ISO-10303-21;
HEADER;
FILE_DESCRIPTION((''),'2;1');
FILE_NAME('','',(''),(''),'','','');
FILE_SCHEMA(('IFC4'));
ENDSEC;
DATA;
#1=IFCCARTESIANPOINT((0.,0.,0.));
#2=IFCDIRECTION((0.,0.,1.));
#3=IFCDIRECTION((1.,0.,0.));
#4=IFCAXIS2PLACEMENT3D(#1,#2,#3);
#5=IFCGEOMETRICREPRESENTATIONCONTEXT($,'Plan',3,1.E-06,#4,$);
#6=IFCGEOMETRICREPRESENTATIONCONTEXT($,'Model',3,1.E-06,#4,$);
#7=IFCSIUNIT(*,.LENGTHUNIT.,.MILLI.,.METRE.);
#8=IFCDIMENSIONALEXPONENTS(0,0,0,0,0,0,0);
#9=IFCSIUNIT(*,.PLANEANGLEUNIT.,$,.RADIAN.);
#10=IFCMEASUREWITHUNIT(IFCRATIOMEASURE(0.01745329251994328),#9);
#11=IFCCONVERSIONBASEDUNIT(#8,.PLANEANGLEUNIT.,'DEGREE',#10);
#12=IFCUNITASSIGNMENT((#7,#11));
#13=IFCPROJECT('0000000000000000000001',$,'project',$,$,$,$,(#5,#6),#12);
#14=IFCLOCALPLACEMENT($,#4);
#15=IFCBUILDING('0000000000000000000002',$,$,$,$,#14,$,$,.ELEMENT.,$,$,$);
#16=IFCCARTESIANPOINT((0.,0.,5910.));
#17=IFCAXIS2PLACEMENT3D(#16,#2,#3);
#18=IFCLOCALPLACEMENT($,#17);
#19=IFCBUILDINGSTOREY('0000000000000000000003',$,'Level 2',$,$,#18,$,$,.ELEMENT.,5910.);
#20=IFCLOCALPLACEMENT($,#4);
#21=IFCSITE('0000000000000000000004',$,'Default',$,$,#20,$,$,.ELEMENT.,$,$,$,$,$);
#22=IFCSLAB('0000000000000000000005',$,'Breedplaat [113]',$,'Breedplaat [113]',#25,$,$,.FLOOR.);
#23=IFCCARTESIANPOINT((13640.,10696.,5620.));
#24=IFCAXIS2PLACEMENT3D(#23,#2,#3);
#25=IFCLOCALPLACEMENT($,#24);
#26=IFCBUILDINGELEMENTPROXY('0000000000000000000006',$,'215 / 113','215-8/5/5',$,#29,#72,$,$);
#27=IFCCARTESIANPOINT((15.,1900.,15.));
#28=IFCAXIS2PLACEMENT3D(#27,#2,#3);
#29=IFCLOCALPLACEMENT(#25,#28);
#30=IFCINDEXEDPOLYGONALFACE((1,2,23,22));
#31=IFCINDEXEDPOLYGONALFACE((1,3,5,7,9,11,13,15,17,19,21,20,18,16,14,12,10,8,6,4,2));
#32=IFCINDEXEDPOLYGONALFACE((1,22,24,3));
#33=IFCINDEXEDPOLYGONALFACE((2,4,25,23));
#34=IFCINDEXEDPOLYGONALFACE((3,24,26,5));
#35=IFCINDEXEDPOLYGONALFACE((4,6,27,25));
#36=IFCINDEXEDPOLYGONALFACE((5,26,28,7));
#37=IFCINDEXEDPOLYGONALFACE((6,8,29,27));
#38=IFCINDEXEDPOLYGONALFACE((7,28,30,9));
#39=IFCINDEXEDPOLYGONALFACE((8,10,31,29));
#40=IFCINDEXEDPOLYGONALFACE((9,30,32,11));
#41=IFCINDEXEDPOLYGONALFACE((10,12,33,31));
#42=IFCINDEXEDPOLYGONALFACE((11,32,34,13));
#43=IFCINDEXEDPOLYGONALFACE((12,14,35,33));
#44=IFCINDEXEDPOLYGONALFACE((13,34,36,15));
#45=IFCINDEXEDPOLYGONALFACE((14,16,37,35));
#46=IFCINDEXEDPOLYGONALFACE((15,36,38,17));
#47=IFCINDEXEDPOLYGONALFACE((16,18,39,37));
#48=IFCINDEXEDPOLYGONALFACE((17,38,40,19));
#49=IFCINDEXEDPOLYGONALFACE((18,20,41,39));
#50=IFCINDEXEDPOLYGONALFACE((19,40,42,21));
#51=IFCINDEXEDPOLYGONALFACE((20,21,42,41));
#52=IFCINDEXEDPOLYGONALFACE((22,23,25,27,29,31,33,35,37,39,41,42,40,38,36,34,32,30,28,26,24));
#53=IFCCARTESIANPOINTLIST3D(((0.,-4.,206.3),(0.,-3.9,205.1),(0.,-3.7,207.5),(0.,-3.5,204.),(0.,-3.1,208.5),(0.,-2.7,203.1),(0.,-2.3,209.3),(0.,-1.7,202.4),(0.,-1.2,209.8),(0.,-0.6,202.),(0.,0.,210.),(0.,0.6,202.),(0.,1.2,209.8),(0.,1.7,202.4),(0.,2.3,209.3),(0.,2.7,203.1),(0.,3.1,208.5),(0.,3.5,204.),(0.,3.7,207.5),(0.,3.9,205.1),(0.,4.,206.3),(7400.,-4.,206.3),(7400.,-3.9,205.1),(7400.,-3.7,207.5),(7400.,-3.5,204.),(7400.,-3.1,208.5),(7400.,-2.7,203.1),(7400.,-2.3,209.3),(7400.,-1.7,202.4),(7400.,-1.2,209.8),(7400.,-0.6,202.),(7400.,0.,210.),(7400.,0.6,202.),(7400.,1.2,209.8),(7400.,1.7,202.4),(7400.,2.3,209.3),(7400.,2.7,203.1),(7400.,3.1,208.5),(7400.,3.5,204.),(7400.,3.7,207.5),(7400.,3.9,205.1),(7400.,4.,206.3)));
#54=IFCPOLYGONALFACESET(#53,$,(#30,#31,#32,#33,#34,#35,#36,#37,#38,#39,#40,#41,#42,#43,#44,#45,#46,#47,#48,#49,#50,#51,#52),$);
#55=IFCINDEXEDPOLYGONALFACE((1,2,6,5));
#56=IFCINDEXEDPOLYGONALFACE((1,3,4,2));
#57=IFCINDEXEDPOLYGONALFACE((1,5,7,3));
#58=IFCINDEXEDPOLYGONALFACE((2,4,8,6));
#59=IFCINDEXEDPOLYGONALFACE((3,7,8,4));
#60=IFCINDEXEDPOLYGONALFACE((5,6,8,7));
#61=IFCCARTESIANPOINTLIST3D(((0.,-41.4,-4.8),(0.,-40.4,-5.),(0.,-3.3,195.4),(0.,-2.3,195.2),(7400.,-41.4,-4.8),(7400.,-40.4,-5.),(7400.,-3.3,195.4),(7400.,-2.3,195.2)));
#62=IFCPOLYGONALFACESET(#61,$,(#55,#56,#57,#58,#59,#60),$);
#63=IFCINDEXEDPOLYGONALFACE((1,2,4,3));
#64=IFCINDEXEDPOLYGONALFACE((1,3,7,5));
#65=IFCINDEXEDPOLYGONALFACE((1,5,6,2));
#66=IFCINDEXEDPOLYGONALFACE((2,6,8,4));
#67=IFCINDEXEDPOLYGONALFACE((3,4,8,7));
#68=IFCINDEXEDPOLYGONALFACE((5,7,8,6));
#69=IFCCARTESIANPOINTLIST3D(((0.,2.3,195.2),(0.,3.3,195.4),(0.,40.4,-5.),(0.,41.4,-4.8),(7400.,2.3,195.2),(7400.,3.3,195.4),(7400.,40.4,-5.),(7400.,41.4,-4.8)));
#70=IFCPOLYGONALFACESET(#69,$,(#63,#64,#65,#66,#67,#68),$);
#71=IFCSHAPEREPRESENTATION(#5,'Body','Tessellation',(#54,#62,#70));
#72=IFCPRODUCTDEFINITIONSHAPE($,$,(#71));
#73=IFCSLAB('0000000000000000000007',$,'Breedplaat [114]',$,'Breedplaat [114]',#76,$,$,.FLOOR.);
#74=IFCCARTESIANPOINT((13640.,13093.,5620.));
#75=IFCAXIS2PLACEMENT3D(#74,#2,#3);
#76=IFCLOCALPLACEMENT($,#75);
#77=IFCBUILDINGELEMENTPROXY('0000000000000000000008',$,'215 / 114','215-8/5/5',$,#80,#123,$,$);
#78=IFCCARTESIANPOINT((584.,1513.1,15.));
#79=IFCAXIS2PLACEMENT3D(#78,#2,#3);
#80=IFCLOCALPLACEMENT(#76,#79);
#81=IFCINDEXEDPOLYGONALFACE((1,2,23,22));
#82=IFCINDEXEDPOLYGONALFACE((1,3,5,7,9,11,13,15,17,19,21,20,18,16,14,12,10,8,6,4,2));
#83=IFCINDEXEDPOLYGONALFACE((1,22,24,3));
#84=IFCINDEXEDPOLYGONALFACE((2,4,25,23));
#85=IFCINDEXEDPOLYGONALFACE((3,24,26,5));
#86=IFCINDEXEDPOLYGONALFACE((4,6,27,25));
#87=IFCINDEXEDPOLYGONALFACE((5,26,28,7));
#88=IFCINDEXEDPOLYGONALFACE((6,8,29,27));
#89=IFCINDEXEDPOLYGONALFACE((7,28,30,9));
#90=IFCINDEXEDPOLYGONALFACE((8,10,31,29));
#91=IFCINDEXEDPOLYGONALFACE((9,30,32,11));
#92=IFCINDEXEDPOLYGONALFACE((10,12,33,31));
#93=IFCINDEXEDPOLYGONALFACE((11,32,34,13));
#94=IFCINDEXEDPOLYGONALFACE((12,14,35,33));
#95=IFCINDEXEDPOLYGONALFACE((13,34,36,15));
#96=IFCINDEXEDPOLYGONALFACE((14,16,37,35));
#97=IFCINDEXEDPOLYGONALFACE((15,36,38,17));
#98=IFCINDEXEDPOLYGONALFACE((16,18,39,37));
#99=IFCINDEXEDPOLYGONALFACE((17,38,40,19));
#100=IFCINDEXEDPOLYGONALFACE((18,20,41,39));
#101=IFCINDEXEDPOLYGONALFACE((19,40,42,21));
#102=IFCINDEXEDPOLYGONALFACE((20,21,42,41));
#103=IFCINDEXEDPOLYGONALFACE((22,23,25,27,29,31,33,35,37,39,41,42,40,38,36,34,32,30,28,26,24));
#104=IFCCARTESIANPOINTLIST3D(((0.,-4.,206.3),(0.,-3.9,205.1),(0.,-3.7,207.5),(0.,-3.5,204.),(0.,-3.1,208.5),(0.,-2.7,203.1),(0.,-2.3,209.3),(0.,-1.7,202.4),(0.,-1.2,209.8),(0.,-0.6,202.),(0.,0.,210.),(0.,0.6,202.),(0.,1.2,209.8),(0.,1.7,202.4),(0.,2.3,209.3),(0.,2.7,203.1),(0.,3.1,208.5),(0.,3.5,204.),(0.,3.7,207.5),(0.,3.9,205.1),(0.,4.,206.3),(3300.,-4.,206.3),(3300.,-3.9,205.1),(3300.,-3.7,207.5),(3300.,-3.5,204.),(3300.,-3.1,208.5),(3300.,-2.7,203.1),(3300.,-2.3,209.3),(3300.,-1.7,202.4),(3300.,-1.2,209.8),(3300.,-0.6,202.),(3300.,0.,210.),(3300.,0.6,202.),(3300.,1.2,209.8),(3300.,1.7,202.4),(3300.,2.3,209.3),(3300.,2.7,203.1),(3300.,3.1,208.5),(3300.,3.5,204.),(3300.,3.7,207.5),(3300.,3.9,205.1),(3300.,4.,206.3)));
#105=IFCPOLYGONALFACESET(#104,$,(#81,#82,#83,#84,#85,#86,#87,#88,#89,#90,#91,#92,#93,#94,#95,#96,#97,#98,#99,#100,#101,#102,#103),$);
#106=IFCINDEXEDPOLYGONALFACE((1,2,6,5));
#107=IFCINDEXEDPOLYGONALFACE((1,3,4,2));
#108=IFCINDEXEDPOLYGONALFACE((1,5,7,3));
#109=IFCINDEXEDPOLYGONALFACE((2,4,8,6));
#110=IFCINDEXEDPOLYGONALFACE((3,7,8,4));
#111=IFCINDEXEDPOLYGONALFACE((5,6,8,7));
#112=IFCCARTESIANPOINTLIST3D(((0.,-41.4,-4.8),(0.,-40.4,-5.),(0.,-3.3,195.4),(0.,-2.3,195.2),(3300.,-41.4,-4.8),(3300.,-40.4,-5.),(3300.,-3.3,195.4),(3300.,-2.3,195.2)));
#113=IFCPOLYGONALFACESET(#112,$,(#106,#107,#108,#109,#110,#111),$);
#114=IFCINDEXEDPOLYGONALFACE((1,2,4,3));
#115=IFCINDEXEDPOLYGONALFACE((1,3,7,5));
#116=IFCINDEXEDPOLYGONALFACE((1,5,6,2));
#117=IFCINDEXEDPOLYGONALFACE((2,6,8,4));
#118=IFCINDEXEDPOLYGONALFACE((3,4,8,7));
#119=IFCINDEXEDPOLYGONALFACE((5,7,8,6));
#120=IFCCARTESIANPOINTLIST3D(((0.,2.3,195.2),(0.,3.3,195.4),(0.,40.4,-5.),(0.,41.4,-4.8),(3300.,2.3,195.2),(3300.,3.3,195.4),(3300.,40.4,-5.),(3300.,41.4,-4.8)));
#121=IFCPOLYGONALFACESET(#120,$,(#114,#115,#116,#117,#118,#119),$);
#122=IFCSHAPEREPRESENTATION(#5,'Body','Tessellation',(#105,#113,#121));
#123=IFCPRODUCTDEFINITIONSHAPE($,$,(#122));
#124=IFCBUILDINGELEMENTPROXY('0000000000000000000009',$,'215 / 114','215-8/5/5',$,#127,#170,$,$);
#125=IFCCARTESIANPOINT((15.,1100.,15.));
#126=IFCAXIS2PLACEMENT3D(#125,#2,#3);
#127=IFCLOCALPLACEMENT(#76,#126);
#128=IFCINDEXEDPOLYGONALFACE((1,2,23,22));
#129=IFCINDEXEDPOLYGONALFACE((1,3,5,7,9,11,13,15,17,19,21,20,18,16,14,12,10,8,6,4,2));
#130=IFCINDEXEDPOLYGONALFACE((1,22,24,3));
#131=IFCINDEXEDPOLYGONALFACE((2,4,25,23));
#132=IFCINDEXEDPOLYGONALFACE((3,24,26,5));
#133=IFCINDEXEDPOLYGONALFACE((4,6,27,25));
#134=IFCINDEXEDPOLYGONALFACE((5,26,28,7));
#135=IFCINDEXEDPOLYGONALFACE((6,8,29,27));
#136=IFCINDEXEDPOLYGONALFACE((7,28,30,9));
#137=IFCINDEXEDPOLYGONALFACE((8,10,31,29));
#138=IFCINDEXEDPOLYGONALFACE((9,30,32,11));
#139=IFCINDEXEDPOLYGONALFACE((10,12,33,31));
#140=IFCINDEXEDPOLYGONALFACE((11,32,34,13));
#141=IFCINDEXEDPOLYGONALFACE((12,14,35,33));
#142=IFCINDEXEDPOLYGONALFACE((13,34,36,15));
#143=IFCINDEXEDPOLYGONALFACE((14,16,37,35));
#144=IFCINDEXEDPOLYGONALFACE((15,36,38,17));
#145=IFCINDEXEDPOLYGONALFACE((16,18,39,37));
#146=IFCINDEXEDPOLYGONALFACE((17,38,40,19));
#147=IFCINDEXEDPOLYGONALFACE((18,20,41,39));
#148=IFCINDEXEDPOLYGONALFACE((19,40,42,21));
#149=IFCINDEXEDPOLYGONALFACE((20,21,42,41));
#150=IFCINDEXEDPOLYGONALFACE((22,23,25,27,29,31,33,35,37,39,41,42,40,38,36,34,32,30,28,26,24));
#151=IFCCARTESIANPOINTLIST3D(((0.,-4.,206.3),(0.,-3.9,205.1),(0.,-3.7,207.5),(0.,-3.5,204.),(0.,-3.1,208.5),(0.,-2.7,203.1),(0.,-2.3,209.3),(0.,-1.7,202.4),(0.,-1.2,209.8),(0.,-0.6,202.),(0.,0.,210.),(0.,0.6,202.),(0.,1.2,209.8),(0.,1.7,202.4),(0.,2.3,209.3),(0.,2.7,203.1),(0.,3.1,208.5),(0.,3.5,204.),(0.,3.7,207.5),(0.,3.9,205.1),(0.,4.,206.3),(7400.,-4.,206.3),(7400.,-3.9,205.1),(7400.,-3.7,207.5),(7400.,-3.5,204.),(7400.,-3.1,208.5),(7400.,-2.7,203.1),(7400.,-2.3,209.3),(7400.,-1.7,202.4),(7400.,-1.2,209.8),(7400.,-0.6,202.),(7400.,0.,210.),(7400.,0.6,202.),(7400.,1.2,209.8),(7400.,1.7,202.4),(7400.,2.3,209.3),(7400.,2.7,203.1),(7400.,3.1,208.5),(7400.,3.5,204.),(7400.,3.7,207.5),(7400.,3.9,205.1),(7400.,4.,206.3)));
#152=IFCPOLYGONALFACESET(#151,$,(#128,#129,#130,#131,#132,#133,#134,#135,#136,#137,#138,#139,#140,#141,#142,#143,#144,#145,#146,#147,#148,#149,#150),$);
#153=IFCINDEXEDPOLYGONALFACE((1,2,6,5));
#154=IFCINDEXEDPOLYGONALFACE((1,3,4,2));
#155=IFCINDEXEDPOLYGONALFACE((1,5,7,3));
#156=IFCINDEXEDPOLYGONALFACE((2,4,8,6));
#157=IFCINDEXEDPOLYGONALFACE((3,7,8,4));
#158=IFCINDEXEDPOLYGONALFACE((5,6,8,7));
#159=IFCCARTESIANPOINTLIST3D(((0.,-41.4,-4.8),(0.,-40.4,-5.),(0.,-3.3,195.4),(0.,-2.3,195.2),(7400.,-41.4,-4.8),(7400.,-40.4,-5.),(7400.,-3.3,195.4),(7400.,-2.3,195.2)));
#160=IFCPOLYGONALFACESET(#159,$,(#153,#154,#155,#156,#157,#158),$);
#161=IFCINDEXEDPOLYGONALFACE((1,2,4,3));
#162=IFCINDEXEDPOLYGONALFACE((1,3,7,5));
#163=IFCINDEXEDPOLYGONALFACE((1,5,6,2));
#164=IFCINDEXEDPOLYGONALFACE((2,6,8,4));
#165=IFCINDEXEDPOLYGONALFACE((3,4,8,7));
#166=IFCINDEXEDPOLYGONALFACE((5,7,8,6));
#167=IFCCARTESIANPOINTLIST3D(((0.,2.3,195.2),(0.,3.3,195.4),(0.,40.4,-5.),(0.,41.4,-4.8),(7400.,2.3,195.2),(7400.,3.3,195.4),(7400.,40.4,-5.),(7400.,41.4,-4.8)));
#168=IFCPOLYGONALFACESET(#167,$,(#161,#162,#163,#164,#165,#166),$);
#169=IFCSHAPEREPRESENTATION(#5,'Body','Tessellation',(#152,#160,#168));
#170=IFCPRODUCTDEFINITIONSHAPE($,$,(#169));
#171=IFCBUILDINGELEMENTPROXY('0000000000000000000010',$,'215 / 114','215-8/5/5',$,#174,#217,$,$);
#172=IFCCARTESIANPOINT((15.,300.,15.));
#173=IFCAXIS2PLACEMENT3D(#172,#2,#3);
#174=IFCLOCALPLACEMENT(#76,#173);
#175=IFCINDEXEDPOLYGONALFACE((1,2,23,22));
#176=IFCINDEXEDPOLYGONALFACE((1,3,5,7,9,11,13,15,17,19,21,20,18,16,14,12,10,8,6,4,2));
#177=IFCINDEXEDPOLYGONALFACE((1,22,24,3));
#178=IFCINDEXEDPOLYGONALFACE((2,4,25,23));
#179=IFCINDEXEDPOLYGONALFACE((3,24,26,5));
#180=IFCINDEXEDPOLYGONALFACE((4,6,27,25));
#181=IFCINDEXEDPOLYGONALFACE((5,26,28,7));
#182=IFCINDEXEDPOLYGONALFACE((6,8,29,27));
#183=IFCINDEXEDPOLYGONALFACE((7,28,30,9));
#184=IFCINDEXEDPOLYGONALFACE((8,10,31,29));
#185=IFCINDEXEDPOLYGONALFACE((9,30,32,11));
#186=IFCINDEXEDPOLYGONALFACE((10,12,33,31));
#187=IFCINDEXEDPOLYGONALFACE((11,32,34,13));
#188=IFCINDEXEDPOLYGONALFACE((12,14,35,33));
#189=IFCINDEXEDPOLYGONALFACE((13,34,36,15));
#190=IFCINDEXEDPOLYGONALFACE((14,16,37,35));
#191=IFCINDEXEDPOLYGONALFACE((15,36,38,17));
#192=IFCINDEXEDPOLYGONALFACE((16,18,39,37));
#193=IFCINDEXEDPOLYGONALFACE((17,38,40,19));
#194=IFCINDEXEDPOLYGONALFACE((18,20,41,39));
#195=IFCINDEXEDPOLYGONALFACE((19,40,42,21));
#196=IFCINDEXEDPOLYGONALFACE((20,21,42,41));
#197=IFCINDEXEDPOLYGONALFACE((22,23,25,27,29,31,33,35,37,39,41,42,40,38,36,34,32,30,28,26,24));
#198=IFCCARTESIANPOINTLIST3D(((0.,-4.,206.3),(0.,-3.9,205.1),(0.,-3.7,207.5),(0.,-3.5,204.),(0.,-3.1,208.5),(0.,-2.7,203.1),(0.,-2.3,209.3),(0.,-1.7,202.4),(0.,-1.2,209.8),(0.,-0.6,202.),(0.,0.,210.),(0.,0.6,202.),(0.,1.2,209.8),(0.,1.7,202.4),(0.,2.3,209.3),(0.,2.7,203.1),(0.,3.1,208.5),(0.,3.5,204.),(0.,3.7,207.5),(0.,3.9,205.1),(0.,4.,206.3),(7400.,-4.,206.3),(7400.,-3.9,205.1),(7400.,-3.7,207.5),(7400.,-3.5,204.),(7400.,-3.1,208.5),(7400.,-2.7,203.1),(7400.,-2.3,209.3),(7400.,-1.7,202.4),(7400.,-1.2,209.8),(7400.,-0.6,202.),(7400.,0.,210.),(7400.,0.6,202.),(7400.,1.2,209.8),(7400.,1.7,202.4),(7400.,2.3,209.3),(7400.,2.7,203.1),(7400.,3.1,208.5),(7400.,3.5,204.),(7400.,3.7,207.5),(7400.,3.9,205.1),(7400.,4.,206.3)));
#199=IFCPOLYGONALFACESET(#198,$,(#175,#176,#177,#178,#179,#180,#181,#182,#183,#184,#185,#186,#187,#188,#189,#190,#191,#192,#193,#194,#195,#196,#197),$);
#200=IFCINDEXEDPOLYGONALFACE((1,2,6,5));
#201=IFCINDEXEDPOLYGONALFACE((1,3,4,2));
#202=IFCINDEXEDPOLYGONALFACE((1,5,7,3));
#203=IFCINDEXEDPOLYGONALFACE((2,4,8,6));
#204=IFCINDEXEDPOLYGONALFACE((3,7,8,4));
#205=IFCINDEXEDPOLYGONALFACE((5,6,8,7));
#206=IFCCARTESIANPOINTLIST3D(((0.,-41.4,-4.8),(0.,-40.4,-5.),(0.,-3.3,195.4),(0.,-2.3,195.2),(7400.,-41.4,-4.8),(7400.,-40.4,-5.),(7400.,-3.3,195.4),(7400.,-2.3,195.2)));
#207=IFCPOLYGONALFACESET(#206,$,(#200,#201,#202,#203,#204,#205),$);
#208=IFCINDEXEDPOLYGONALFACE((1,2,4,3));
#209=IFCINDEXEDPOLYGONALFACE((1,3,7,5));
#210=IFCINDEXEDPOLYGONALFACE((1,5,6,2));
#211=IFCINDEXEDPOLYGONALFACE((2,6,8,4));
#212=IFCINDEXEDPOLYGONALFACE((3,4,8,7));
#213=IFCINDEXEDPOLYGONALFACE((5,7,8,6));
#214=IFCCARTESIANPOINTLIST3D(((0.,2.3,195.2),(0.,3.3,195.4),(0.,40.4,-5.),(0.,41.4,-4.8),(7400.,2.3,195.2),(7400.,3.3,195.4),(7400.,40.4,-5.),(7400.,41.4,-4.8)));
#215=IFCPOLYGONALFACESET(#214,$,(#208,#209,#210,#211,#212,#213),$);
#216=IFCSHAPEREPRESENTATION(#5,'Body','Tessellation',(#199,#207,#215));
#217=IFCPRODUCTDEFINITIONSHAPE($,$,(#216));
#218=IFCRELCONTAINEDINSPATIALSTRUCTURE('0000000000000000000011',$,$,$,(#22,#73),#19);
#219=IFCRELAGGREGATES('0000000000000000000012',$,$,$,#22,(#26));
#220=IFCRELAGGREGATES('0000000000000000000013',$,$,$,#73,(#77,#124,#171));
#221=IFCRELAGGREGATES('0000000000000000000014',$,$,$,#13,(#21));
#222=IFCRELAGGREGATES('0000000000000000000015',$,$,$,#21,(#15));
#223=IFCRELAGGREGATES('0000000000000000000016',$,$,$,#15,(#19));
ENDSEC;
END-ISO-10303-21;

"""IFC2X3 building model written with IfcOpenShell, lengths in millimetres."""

from ifc_helpers import new_model, entity, si_unit, converted_unit, frame, origin_with_axes, origin_2d_with_axis, place, context, project, spatial, rectangle, circle, extrude, element, aggregate, save


model = new_model("IFC2X3")

# Units and contexts
plan_context = context("Plan", 3, precision=1e-06, world=origin_with_axes())
model_context = context("Model", 3, precision=1e-06, world=origin_with_axes())
ifc_project = project(units=[si_unit("LENGTHUNIT", "METRE", prefix="MILLI"), converted_unit("PLANEANGLEUNIT", "DEGREE", entity("IfcRatioMeasure", 0.01745329251994328), si_unit("PLANEANGLEUNIT", "RADIAN"), dimensions=[0, 0, 0, 0, 0, 0, 0])], contexts=[plan_context, model_context])

# Site, building, storey
site_placement = place(None, origin_with_axes())
site = spatial("IfcSite", under=ifc_project, at=site_placement, Name="Default", CompositionType="ELEMENT")
building_placement = place(None, origin_with_axes())
building = spatial("IfcBuilding", under=site, at=building_placement, CompositionType="ELEMENT")
storey_placement = place(None, frame((0.0, 0.0, 5910.0), z_axis=(0.0, 0.0, 1.0), x_axis=(1.0, 0.0, 0.0)))
storey = spatial("IfcBuildingStorey", under=building, at=storey_placement, Name="Level 2", CompositionType="ELEMENT", Elevation=5910.0)

# Slabs, building element proxies
slab_1_placement = place(None, frame((13640.0, 10696.0, 5620.0), z_axis=(0.0, 0.0, 1.0), x_axis=(1.0, 0.0, 0.0)))
slab_1 = element("IfcSlab", 1, at=slab_1_placement, inside=storey, Name="Breedplaat [113]", ObjectType="Breedplaat [113]", PredefinedType="FLOOR")
proxy_1_placement = place(slab_1_placement, frame((15.0, 1900.0, 15.0), z_axis=(0.0, 0.0, 1.0), x_axis=(1.0, 0.0, 0.0)))
proxy_1 = element("IfcBuildingElementProxy", 2, at=proxy_1_placement, Name="215 / 113", Description="215-8/5/5", context=plan_context, shape_type="SweptSolid", body=[
    extrude(circle(Radius=4.0, at=origin_2d_with_axis()), frame((0.0, 0.0, 206.0), z_axis=(1.0, 0.0, 0.0), x_axis=(0.0, 0.0, 1.0)), (0.0, 0.0, 1.0), 7400.0),
    extrude(rectangle(XDim=203.8, YDim=1.0, at=origin_2d_with_axis()), frame((0.0, -21.9, 95.2), z_axis=(1.0, 0.0, 0.0), x_axis=(0.0, 0.187112, 0.982339)), (0.0, 0.0, 1.0), 7400.0),
    extrude(rectangle(XDim=203.8, YDim=1.0, at=origin_2d_with_axis()), frame((0.0, 21.9, 95.2), z_axis=(1.0, 0.0, 0.0), x_axis=(0.0, -0.187112, 0.982339)), (0.0, 0.0, 1.0), 7400.0),
])
aggregate(slab_1, [proxy_1])
slab_2_placement = place(None, frame((13640.0, 13093.0, 5620.0), z_axis=(0.0, 0.0, 1.0), x_axis=(1.0, 0.0, 0.0)))
slab_2 = element("IfcSlab", 3, at=slab_2_placement, inside=storey, Name="Breedplaat [114]", ObjectType="Breedplaat [114]", PredefinedType="FLOOR")
proxy_2_placement = place(slab_2_placement, frame((584.0, 1513.1, 15.0), z_axis=(0.0, 0.0, 1.0), x_axis=(1.0, 0.0, 0.0)))
proxy_2 = element("IfcBuildingElementProxy", 4, at=proxy_2_placement, Name="215 / 114", Description="215-8/5/5", context=plan_context, shape_type="SweptSolid", body=[
    extrude(circle(Radius=4.0, at=origin_2d_with_axis()), frame((0.0, 0.0, 206.0), z_axis=(1.0, 0.0, 0.0), x_axis=(0.0, 0.0, 1.0)), (0.0, 0.0, 1.0), 3300.0),
    extrude(rectangle(XDim=203.8, YDim=1.0, at=origin_2d_with_axis()), frame((0.0, -21.9, 95.2), z_axis=(1.0, 0.0, 0.0), x_axis=(0.0, 0.187112, 0.982339)), (0.0, 0.0, 1.0), 3300.0),
    extrude(rectangle(XDim=203.8, YDim=1.0, at=origin_2d_with_axis()), frame((0.0, 21.9, 95.2), z_axis=(1.0, 0.0, 0.0), x_axis=(0.0, -0.187112, 0.982339)), (0.0, 0.0, 1.0), 3300.0),
])
proxy_3_placement = place(slab_2_placement, frame((15.0, 1100.0, 15.0), z_axis=(0.0, 0.0, 1.0), x_axis=(1.0, 0.0, 0.0)))
proxy_3 = element("IfcBuildingElementProxy", 5, at=proxy_3_placement, Name="215 / 114", Description="215-8/5/5", context=plan_context, shape_type="SweptSolid", body=[
    extrude(circle(Radius=4.0, at=origin_2d_with_axis()), frame((0.0, 0.0, 206.0), z_axis=(1.0, 0.0, 0.0), x_axis=(0.0, 0.0, 1.0)), (0.0, 0.0, 1.0), 7400.0),
    extrude(rectangle(XDim=203.8, YDim=1.0, at=origin_2d_with_axis()), frame((0.0, -21.9, 95.2), z_axis=(1.0, 0.0, 0.0), x_axis=(0.0, 0.187112, 0.982339)), (0.0, 0.0, 1.0), 7400.0),
    extrude(rectangle(XDim=203.8, YDim=1.0, at=origin_2d_with_axis()), frame((0.0, 21.9, 95.2), z_axis=(1.0, 0.0, 0.0), x_axis=(0.0, -0.187112, 0.982339)), (0.0, 0.0, 1.0), 7400.0),
])
proxy_4_placement = place(slab_2_placement, frame((15.0, 300.0, 15.0), z_axis=(0.0, 0.0, 1.0), x_axis=(1.0, 0.0, 0.0)))
proxy_4 = element("IfcBuildingElementProxy", 6, at=proxy_4_placement, Name="215 / 114", Description="215-8/5/5", context=plan_context, shape_type="SweptSolid", body=[
    extrude(circle(Radius=4.0, at=origin_2d_with_axis()), frame((0.0, 0.0, 206.0), z_axis=(1.0, 0.0, 0.0), x_axis=(0.0, 0.0, 1.0)), (0.0, 0.0, 1.0), 7400.0),
    extrude(rectangle(XDim=203.8, YDim=1.0, at=origin_2d_with_axis()), frame((0.0, -21.9, 95.2), z_axis=(1.0, 0.0, 0.0), x_axis=(0.0, 0.187112, 0.982339)), (0.0, 0.0, 1.0), 7400.0),
    extrude(rectangle(XDim=203.8, YDim=1.0, at=origin_2d_with_axis()), frame((0.0, 21.9, 95.2), z_axis=(1.0, 0.0, 0.0), x_axis=(0.0, -0.187112, 0.982339)), (0.0, 0.0, 1.0), 7400.0),
])
aggregate(slab_2, [proxy_2, proxy_3, proxy_4])

save(model, "model.ifc")
